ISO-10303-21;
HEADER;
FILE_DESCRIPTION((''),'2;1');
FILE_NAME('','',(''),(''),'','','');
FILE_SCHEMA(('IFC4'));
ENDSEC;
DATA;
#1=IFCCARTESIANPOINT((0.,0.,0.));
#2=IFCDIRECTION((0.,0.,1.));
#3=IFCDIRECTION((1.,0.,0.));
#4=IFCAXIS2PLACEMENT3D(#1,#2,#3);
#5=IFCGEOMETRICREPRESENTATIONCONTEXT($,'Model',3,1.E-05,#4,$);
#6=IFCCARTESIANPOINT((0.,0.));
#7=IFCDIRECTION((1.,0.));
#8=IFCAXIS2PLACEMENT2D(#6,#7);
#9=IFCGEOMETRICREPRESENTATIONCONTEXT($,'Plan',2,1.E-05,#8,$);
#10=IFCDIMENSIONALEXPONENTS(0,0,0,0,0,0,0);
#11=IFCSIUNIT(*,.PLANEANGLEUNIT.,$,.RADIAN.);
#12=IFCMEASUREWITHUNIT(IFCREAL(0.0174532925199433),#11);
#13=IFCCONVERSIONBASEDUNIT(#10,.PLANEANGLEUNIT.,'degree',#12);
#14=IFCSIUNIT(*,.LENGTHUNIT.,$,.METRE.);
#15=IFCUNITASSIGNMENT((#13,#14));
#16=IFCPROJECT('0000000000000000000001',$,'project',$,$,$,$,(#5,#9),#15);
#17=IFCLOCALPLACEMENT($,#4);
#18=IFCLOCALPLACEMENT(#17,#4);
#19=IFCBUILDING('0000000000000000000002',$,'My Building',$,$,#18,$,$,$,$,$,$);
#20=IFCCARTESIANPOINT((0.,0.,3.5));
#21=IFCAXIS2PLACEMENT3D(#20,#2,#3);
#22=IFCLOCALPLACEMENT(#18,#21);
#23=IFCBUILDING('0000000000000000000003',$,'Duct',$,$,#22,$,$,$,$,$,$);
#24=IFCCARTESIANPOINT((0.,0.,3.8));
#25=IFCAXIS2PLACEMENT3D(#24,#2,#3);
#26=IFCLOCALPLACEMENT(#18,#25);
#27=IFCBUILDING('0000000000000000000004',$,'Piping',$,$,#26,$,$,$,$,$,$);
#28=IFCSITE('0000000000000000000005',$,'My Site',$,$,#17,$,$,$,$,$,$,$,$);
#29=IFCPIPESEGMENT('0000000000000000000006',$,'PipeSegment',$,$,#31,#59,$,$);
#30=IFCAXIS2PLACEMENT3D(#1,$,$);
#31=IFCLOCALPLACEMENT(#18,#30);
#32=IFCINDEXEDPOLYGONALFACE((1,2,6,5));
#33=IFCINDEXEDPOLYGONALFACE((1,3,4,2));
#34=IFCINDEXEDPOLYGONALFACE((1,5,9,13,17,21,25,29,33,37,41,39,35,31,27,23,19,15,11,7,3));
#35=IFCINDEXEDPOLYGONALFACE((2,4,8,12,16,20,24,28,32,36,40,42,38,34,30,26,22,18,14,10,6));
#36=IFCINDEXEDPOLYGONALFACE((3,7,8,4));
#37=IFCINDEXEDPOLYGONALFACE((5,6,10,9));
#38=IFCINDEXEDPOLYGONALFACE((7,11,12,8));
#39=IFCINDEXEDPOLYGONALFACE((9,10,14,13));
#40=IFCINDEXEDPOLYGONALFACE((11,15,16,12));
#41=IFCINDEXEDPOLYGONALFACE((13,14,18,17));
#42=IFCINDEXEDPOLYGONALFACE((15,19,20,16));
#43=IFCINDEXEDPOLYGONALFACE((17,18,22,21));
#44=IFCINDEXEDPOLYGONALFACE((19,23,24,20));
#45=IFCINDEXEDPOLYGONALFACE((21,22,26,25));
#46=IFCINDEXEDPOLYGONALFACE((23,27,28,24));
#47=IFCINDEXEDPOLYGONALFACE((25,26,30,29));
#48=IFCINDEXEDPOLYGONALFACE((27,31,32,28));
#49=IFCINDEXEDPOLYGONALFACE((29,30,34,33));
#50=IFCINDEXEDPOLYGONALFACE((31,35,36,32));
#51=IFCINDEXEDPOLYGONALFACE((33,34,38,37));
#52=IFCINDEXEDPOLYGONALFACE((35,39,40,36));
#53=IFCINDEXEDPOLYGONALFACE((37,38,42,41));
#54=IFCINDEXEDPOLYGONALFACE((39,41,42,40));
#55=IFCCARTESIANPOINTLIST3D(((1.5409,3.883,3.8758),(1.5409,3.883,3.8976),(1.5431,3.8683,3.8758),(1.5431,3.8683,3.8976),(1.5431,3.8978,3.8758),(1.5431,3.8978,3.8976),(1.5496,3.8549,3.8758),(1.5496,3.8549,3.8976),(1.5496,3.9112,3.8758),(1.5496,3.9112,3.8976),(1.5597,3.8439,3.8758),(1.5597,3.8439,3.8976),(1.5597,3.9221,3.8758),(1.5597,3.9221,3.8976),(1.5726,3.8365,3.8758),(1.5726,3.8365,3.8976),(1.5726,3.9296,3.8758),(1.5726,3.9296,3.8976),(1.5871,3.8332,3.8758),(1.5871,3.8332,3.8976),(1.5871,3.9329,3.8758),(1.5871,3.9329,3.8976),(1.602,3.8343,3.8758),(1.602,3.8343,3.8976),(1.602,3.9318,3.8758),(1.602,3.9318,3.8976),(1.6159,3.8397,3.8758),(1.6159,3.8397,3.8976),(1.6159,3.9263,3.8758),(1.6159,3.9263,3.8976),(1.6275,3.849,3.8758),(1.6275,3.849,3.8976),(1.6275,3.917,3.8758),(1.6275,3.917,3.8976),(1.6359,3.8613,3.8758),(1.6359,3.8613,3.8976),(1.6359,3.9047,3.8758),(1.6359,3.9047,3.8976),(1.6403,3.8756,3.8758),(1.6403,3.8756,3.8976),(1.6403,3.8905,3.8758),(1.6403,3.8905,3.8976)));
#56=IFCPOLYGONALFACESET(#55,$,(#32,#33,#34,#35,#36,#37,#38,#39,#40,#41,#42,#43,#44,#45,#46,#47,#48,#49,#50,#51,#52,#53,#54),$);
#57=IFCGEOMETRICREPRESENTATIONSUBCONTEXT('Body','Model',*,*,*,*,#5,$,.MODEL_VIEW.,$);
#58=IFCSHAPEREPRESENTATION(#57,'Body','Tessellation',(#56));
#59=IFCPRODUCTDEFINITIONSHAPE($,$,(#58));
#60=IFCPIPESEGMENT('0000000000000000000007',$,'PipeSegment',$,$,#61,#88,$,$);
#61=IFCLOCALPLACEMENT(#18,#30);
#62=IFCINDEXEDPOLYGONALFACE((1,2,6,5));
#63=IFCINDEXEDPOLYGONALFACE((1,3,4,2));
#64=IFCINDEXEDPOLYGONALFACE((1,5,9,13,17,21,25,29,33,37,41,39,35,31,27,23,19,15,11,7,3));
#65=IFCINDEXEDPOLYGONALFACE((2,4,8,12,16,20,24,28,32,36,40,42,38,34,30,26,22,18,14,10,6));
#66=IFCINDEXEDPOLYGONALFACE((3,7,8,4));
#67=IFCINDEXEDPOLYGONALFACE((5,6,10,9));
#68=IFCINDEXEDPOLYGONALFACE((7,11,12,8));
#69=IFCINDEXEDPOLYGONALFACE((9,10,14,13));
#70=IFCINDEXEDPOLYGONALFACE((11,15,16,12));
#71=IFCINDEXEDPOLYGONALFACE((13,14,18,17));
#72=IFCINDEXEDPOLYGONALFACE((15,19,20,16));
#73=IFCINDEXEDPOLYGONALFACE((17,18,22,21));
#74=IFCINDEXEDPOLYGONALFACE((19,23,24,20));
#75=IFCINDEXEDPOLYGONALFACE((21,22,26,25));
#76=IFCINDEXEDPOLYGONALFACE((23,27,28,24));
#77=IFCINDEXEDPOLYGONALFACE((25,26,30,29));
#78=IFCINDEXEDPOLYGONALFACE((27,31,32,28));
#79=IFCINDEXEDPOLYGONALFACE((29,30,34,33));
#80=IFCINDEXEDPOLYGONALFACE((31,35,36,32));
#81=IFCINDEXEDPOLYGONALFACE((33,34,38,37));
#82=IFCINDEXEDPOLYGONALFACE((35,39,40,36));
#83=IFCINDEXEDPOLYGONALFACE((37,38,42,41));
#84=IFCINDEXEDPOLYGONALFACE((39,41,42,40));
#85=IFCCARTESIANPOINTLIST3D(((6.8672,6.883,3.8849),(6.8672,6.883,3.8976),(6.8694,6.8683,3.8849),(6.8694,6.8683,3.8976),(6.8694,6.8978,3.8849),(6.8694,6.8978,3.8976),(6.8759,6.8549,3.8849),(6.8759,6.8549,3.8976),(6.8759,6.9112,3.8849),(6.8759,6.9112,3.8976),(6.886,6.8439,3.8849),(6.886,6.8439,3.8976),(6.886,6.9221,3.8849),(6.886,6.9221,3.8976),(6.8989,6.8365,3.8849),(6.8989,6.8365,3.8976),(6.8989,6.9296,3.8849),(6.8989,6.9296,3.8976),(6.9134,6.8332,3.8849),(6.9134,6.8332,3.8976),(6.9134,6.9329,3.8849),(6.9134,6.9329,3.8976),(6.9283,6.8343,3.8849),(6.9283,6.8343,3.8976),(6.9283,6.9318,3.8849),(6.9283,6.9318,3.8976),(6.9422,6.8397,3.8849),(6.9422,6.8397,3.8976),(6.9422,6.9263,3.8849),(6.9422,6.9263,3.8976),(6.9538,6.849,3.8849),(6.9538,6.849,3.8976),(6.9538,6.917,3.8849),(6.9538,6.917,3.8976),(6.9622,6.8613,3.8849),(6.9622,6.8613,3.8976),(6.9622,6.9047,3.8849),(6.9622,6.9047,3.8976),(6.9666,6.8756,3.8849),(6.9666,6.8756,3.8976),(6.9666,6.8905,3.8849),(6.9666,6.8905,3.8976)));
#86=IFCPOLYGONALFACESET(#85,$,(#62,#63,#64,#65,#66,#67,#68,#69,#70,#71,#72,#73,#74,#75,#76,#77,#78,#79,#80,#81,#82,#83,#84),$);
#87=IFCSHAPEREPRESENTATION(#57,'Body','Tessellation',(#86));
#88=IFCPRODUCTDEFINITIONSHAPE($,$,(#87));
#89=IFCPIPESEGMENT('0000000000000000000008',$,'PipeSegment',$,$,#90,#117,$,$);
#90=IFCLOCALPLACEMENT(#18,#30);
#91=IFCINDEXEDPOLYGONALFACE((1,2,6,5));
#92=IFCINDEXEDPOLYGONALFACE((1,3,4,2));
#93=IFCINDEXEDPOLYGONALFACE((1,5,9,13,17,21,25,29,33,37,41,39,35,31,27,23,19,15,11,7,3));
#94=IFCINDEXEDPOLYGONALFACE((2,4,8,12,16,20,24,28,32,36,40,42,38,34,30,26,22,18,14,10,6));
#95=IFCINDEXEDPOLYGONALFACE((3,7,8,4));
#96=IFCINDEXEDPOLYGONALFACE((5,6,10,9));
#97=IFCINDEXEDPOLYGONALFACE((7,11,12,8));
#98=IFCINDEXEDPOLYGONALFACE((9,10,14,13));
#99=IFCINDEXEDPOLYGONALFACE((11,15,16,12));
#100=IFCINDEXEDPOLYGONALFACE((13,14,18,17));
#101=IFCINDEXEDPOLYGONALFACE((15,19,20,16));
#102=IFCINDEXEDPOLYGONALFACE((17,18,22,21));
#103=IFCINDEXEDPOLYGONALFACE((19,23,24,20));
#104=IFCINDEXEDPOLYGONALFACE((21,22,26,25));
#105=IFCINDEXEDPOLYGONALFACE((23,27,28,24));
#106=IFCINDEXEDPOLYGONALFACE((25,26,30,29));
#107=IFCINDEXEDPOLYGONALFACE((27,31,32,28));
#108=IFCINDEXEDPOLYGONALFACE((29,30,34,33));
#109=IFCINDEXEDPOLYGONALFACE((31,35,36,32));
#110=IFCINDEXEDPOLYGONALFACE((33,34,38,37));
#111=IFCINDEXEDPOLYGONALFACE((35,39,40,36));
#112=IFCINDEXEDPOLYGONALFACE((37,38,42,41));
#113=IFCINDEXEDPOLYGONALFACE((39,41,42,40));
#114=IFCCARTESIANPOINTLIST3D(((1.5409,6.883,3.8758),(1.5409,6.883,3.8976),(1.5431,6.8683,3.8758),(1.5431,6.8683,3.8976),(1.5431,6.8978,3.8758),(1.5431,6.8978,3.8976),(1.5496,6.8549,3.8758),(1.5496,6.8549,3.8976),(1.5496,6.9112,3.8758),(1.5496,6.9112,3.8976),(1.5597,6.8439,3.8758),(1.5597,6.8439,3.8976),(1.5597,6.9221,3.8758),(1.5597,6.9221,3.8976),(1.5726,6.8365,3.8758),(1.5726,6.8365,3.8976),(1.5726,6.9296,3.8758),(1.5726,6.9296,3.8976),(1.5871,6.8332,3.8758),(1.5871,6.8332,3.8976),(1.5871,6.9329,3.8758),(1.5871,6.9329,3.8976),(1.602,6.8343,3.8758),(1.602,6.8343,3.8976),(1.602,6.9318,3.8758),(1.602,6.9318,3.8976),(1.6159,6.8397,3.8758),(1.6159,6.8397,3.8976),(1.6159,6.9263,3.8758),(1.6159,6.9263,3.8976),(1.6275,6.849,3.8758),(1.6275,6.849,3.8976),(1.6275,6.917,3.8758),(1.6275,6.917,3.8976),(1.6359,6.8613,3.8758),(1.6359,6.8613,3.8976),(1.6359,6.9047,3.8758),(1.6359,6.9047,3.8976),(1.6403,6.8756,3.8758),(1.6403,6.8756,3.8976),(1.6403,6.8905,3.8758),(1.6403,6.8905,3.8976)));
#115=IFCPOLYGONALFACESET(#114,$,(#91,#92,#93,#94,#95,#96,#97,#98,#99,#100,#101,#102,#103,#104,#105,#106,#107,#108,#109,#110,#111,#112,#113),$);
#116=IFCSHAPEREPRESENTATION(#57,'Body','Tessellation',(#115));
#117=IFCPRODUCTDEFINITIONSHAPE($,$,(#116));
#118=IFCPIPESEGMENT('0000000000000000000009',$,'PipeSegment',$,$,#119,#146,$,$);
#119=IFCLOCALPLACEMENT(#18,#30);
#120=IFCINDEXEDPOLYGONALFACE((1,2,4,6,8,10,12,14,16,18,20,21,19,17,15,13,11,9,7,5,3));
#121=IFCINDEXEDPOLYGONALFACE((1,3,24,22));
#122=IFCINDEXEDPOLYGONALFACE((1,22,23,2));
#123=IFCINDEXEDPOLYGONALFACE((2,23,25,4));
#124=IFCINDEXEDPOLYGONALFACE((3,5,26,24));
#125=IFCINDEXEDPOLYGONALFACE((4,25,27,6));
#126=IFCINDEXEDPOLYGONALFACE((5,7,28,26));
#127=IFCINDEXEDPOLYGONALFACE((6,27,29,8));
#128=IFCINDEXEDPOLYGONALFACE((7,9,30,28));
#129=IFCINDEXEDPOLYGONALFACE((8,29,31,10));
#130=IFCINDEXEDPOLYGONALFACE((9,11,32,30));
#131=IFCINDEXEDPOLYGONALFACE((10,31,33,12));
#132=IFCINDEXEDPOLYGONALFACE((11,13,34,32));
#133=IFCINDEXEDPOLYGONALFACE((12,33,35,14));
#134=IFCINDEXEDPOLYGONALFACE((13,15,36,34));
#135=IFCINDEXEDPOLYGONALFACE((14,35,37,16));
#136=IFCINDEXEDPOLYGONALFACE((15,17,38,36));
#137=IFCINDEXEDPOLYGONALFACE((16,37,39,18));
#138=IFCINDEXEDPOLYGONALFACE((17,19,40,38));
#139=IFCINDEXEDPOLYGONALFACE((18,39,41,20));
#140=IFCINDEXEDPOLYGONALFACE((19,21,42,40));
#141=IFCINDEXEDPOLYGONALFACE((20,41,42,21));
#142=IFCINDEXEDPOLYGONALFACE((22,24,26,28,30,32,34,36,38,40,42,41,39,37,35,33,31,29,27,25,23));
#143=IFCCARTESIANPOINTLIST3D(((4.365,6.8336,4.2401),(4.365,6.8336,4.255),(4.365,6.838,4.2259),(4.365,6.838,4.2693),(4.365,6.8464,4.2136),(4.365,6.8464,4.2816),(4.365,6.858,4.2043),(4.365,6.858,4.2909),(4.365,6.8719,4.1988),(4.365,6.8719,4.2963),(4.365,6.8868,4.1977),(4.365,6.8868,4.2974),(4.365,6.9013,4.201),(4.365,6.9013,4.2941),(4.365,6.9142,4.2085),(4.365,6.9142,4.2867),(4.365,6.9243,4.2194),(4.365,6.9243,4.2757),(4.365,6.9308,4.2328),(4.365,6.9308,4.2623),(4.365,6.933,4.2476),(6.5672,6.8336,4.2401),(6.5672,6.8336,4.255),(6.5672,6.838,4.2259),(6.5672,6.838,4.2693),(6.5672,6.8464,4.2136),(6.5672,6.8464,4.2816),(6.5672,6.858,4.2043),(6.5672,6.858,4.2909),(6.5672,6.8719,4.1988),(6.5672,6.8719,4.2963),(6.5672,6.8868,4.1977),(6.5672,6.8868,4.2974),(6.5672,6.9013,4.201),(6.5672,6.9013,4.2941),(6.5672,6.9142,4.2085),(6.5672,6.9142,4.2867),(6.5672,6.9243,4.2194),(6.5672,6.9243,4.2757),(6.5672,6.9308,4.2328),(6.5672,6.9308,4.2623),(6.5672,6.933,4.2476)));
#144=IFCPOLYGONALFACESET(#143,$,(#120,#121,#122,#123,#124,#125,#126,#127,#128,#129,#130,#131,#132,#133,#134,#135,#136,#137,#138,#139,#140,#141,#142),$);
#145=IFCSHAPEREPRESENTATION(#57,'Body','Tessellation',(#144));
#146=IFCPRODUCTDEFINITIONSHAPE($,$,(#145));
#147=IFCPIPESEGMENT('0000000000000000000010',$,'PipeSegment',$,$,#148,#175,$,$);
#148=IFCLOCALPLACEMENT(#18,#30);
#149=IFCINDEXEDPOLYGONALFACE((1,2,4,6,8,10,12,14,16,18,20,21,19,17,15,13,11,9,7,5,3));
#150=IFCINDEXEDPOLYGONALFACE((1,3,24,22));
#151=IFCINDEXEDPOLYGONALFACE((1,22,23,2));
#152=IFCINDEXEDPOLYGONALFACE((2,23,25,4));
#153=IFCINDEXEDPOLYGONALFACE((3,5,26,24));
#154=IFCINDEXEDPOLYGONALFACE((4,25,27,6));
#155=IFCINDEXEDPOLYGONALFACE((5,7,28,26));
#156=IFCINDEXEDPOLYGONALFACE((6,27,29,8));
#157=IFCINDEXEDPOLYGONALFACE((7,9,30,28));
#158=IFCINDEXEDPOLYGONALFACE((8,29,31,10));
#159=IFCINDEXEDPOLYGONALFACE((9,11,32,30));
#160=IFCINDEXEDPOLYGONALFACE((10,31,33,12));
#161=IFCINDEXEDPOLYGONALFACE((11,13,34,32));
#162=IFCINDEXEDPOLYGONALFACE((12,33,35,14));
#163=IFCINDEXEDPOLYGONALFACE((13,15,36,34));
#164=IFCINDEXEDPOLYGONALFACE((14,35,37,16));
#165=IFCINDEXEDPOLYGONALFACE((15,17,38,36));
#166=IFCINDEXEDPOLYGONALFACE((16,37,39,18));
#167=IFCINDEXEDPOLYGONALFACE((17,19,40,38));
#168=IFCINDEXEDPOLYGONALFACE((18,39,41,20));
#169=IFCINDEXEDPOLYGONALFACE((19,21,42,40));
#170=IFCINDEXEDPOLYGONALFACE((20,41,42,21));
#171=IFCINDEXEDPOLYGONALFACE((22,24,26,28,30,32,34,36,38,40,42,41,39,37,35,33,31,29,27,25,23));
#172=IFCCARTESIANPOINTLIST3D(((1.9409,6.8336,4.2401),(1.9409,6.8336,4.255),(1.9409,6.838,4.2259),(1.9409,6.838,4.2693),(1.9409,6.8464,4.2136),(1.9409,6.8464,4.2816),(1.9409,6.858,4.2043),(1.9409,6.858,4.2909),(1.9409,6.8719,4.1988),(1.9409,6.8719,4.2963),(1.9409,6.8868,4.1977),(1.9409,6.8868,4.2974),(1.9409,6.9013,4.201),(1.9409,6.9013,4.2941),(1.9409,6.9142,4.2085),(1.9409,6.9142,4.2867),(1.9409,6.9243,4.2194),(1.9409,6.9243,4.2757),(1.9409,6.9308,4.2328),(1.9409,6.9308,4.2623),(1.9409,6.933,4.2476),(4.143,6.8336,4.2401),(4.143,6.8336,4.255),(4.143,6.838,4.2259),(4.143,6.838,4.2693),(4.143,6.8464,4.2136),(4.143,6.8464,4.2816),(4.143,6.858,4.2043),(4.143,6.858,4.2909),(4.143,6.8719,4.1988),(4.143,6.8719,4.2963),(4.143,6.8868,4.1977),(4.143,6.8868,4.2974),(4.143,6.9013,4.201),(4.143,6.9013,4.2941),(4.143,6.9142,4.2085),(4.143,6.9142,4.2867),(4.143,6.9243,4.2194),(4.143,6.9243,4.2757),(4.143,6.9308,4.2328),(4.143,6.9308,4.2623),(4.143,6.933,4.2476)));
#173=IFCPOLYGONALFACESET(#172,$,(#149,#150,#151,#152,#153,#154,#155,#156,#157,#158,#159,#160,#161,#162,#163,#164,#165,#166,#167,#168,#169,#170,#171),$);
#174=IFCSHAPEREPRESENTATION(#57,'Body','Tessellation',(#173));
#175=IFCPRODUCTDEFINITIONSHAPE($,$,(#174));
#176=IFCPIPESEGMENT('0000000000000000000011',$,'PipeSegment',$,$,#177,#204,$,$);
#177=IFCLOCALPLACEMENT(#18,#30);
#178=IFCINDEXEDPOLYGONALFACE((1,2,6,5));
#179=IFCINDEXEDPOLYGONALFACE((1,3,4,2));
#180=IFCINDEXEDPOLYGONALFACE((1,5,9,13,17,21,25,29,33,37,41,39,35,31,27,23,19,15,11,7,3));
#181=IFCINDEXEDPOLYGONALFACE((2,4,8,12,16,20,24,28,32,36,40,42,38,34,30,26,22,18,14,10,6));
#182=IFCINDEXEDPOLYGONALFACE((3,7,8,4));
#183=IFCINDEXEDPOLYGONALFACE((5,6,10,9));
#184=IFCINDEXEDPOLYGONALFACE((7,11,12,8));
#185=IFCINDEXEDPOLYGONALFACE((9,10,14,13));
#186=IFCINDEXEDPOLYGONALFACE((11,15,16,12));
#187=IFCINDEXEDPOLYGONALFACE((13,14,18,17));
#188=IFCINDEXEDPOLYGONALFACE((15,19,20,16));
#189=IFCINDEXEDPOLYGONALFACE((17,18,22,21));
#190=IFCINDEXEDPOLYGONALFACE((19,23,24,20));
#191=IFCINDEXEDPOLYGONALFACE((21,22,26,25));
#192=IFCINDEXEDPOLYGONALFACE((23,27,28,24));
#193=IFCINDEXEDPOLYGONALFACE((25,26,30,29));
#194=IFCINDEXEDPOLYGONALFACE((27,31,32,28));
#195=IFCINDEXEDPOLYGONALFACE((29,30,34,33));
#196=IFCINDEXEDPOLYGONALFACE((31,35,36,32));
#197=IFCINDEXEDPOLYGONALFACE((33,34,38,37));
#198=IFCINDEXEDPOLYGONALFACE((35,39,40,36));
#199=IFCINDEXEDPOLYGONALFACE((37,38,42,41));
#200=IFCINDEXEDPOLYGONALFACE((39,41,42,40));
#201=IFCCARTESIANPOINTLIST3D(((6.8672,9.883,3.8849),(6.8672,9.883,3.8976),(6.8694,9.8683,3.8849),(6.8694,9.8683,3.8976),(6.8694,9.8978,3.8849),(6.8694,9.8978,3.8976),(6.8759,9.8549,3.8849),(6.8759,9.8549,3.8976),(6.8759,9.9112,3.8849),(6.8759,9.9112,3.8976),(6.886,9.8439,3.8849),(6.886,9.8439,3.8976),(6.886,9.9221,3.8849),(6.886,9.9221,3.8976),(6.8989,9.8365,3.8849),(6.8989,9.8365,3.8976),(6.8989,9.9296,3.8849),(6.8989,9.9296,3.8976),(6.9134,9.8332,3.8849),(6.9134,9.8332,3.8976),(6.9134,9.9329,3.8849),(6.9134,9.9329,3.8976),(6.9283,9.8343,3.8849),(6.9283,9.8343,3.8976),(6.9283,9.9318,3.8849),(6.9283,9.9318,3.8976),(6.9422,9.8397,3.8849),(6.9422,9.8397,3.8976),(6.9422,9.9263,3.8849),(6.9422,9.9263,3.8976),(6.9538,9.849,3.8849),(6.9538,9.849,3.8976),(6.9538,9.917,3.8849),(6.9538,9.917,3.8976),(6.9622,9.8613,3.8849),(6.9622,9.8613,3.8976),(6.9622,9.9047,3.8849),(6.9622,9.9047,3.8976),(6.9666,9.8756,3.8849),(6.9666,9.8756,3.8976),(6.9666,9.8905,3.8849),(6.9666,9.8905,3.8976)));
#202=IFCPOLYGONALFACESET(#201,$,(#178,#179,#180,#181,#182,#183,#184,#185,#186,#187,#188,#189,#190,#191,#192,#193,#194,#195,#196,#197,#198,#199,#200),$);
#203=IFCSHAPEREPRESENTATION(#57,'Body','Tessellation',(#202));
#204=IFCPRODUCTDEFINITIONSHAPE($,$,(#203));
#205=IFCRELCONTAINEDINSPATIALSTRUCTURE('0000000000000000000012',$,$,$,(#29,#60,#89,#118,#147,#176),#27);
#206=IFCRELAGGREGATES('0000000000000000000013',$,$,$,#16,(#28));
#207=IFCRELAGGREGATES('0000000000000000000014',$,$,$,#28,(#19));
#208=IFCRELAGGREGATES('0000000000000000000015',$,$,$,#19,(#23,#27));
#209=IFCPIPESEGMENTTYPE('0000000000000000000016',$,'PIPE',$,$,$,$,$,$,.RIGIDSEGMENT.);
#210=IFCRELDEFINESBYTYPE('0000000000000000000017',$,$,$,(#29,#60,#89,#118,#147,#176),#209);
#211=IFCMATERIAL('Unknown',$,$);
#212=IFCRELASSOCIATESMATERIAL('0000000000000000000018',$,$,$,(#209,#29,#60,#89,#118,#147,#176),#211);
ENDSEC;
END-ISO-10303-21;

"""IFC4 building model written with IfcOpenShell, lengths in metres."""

from ifc_helpers import new_model, entity, si_unit, converted_unit, frame, origin_with_axes, origin_2d_with_axis, place, context, subcontext, project, spatial, circle, extrude, material, material_profile, profile_set, profile_usage, type_object, element, save


model = new_model("IFC4")

# Units and contexts
model_context = context("Model", 3, precision=1e-05, world=origin_with_axes())
plan_context = context("Plan", 2, precision=1e-05, world=origin_2d_with_axis())
body_context = subcontext(model_context, "Body", "Model", "MODEL_VIEW")
ifc_project = project(units=[converted_unit("PLANEANGLEUNIT", "degree", entity("IfcReal", 0.0174532925199433), si_unit("PLANEANGLEUNIT", "RADIAN"), dimensions=[0, 0, 0, 0, 0, 0, 0]), si_unit("LENGTHUNIT", "METRE")], contexts=[model_context, plan_context])

# Site, building
site_placement = place(None, origin_with_axes())
site = spatial("IfcSite", under=ifc_project, at=site_placement, Name="My Site")
building_1_placement = place(site_placement, origin_with_axes())
building_1 = spatial("IfcBuilding", under=site, at=building_1_placement, Name="My Building")

# Shared definitions
ifc_material = material(Name="Unknown")

# Shared definitions
building_2_placement = place(building_1_placement, frame((0.0, 0.0, 3.5), z_axis=(0.0, 0.0, 1.0), x_axis=(1.0, 0.0, 0.0)))
building_2 = spatial("IfcBuilding", under=building_1, at=building_2_placement, Name="Duct")

# Shared definitions
building_3_placement = place(building_1_placement, frame((0.0, 0.0, 3.8), z_axis=(0.0, 0.0, 1.0), x_axis=(1.0, 0.0, 0.0)))
building_3 = spatial("IfcBuilding", under=building_1, at=building_3_placement, Name="Piping")

# Pipe segments
ifc_material_profile_1 = material_profile(ifc_material, circle(Radius=0.05))
ifc_profile_set_1 = profile_set([ifc_material_profile_1])
pipe_segment_type = type_object("IfcPipeSegmentType", Name="PIPE", PredefinedType="RIGIDSEGMENT", material=ifc_profile_set_1)
ifc_profile_usage_1 = profile_usage(ifc_profile_set_1, cardinal=5)
pipe_segment_1_placement = place(building_3_placement, frame((1.5909, 3.883, 0.0976), z_axis=(0.0, 0.0, -1.0), x_axis=(-1.0, 0.0, 0.0)))
element("IfcPipeSegment", 1, at=pipe_segment_1_placement, inside=building_3, type_object=pipe_segment_type, material=ifc_profile_usage_1, Name="PipeSegment", context=body_context, shape_type="SweptSolid", body=[
    extrude(circle(Radius=0.05), origin_with_axes(), (0.0, 0.0, 1.0), 0.0218),
])
ifc_profile_usage_2 = profile_usage(ifc_profile_set_1, cardinal=5)
pipe_segment_2_placement = place(building_3_placement, frame((6.9172, 6.883, 0.0976), z_axis=(0.0, 0.0, -1.0), x_axis=(-1.0, 0.0, 0.0)))
element("IfcPipeSegment", 2, at=pipe_segment_2_placement, inside=building_3, type_object=pipe_segment_type, material=ifc_profile_usage_2, Name="PipeSegment", context=body_context, shape_type="SweptSolid", body=[
    extrude(circle(Radius=0.05), origin_with_axes(), (0.0, 0.0, 1.0), 0.0127),
])
ifc_profile_usage_3 = profile_usage(ifc_profile_set_1, cardinal=5)
pipe_segment_3_placement = place(building_3_placement, frame((1.5909, 6.883, 0.0976), z_axis=(0.0, 0.0, -1.0), x_axis=(-1.0, 0.0, 0.0)))
element("IfcPipeSegment", 3, at=pipe_segment_3_placement, inside=building_3, type_object=pipe_segment_type, material=ifc_profile_usage_3, Name="PipeSegment", context=body_context, shape_type="SweptSolid", body=[
    extrude(circle(Radius=0.05), origin_with_axes(), (0.0, 0.0, 1.0), 0.0218),
])
ifc_profile_usage_4 = profile_usage(ifc_profile_set_1, cardinal=5)
pipe_segment_4_placement = place(building_3_placement, frame((4.365, 6.883, 0.4476), z_axis=(1.0, -0.000001, 0.000001), x_axis=(0.000001, 1.0, 0.0)))
element("IfcPipeSegment", 4, at=pipe_segment_4_placement, inside=building_3, type_object=pipe_segment_type, material=ifc_profile_usage_4, Name="PipeSegment", context=body_context, shape_type="SweptSolid", body=[
    extrude(circle(Radius=0.05), origin_with_axes(), (0.0, 0.0, 1.0), 2.2022),
])
ifc_profile_usage_5 = profile_usage(ifc_profile_set_1, cardinal=5)
pipe_segment_5_placement = place(building_3_placement, frame((4.143, 6.883, 0.4476), z_axis=(-1.0, -0.000001, -0.000001), x_axis=(-0.000001, 1.0, 0.0)))
element("IfcPipeSegment", 5, at=pipe_segment_5_placement, inside=building_3, type_object=pipe_segment_type, material=ifc_profile_usage_5, Name="PipeSegment", context=body_context, shape_type="SweptSolid", body=[
    extrude(circle(Radius=0.05), origin_with_axes(), (0.0, 0.0, 1.0), 2.2022),
])
ifc_profile_usage_6 = profile_usage(ifc_profile_set_1, cardinal=5)
pipe_segment_6_placement = place(building_3_placement, frame((6.9172, 9.883, 0.0976), z_axis=(0.0, 0.0, -1.0), x_axis=(-1.0, 0.0, 0.0)))
element("IfcPipeSegment", 6, at=pipe_segment_6_placement, inside=building_3, type_object=pipe_segment_type, material=ifc_profile_usage_6, Name="PipeSegment", context=body_context, shape_type="SweptSolid", body=[
    extrude(circle(Radius=0.05), origin_with_axes(), (0.0, 0.0, 1.0), 0.0127),
])

save(model, "model.ifc")
